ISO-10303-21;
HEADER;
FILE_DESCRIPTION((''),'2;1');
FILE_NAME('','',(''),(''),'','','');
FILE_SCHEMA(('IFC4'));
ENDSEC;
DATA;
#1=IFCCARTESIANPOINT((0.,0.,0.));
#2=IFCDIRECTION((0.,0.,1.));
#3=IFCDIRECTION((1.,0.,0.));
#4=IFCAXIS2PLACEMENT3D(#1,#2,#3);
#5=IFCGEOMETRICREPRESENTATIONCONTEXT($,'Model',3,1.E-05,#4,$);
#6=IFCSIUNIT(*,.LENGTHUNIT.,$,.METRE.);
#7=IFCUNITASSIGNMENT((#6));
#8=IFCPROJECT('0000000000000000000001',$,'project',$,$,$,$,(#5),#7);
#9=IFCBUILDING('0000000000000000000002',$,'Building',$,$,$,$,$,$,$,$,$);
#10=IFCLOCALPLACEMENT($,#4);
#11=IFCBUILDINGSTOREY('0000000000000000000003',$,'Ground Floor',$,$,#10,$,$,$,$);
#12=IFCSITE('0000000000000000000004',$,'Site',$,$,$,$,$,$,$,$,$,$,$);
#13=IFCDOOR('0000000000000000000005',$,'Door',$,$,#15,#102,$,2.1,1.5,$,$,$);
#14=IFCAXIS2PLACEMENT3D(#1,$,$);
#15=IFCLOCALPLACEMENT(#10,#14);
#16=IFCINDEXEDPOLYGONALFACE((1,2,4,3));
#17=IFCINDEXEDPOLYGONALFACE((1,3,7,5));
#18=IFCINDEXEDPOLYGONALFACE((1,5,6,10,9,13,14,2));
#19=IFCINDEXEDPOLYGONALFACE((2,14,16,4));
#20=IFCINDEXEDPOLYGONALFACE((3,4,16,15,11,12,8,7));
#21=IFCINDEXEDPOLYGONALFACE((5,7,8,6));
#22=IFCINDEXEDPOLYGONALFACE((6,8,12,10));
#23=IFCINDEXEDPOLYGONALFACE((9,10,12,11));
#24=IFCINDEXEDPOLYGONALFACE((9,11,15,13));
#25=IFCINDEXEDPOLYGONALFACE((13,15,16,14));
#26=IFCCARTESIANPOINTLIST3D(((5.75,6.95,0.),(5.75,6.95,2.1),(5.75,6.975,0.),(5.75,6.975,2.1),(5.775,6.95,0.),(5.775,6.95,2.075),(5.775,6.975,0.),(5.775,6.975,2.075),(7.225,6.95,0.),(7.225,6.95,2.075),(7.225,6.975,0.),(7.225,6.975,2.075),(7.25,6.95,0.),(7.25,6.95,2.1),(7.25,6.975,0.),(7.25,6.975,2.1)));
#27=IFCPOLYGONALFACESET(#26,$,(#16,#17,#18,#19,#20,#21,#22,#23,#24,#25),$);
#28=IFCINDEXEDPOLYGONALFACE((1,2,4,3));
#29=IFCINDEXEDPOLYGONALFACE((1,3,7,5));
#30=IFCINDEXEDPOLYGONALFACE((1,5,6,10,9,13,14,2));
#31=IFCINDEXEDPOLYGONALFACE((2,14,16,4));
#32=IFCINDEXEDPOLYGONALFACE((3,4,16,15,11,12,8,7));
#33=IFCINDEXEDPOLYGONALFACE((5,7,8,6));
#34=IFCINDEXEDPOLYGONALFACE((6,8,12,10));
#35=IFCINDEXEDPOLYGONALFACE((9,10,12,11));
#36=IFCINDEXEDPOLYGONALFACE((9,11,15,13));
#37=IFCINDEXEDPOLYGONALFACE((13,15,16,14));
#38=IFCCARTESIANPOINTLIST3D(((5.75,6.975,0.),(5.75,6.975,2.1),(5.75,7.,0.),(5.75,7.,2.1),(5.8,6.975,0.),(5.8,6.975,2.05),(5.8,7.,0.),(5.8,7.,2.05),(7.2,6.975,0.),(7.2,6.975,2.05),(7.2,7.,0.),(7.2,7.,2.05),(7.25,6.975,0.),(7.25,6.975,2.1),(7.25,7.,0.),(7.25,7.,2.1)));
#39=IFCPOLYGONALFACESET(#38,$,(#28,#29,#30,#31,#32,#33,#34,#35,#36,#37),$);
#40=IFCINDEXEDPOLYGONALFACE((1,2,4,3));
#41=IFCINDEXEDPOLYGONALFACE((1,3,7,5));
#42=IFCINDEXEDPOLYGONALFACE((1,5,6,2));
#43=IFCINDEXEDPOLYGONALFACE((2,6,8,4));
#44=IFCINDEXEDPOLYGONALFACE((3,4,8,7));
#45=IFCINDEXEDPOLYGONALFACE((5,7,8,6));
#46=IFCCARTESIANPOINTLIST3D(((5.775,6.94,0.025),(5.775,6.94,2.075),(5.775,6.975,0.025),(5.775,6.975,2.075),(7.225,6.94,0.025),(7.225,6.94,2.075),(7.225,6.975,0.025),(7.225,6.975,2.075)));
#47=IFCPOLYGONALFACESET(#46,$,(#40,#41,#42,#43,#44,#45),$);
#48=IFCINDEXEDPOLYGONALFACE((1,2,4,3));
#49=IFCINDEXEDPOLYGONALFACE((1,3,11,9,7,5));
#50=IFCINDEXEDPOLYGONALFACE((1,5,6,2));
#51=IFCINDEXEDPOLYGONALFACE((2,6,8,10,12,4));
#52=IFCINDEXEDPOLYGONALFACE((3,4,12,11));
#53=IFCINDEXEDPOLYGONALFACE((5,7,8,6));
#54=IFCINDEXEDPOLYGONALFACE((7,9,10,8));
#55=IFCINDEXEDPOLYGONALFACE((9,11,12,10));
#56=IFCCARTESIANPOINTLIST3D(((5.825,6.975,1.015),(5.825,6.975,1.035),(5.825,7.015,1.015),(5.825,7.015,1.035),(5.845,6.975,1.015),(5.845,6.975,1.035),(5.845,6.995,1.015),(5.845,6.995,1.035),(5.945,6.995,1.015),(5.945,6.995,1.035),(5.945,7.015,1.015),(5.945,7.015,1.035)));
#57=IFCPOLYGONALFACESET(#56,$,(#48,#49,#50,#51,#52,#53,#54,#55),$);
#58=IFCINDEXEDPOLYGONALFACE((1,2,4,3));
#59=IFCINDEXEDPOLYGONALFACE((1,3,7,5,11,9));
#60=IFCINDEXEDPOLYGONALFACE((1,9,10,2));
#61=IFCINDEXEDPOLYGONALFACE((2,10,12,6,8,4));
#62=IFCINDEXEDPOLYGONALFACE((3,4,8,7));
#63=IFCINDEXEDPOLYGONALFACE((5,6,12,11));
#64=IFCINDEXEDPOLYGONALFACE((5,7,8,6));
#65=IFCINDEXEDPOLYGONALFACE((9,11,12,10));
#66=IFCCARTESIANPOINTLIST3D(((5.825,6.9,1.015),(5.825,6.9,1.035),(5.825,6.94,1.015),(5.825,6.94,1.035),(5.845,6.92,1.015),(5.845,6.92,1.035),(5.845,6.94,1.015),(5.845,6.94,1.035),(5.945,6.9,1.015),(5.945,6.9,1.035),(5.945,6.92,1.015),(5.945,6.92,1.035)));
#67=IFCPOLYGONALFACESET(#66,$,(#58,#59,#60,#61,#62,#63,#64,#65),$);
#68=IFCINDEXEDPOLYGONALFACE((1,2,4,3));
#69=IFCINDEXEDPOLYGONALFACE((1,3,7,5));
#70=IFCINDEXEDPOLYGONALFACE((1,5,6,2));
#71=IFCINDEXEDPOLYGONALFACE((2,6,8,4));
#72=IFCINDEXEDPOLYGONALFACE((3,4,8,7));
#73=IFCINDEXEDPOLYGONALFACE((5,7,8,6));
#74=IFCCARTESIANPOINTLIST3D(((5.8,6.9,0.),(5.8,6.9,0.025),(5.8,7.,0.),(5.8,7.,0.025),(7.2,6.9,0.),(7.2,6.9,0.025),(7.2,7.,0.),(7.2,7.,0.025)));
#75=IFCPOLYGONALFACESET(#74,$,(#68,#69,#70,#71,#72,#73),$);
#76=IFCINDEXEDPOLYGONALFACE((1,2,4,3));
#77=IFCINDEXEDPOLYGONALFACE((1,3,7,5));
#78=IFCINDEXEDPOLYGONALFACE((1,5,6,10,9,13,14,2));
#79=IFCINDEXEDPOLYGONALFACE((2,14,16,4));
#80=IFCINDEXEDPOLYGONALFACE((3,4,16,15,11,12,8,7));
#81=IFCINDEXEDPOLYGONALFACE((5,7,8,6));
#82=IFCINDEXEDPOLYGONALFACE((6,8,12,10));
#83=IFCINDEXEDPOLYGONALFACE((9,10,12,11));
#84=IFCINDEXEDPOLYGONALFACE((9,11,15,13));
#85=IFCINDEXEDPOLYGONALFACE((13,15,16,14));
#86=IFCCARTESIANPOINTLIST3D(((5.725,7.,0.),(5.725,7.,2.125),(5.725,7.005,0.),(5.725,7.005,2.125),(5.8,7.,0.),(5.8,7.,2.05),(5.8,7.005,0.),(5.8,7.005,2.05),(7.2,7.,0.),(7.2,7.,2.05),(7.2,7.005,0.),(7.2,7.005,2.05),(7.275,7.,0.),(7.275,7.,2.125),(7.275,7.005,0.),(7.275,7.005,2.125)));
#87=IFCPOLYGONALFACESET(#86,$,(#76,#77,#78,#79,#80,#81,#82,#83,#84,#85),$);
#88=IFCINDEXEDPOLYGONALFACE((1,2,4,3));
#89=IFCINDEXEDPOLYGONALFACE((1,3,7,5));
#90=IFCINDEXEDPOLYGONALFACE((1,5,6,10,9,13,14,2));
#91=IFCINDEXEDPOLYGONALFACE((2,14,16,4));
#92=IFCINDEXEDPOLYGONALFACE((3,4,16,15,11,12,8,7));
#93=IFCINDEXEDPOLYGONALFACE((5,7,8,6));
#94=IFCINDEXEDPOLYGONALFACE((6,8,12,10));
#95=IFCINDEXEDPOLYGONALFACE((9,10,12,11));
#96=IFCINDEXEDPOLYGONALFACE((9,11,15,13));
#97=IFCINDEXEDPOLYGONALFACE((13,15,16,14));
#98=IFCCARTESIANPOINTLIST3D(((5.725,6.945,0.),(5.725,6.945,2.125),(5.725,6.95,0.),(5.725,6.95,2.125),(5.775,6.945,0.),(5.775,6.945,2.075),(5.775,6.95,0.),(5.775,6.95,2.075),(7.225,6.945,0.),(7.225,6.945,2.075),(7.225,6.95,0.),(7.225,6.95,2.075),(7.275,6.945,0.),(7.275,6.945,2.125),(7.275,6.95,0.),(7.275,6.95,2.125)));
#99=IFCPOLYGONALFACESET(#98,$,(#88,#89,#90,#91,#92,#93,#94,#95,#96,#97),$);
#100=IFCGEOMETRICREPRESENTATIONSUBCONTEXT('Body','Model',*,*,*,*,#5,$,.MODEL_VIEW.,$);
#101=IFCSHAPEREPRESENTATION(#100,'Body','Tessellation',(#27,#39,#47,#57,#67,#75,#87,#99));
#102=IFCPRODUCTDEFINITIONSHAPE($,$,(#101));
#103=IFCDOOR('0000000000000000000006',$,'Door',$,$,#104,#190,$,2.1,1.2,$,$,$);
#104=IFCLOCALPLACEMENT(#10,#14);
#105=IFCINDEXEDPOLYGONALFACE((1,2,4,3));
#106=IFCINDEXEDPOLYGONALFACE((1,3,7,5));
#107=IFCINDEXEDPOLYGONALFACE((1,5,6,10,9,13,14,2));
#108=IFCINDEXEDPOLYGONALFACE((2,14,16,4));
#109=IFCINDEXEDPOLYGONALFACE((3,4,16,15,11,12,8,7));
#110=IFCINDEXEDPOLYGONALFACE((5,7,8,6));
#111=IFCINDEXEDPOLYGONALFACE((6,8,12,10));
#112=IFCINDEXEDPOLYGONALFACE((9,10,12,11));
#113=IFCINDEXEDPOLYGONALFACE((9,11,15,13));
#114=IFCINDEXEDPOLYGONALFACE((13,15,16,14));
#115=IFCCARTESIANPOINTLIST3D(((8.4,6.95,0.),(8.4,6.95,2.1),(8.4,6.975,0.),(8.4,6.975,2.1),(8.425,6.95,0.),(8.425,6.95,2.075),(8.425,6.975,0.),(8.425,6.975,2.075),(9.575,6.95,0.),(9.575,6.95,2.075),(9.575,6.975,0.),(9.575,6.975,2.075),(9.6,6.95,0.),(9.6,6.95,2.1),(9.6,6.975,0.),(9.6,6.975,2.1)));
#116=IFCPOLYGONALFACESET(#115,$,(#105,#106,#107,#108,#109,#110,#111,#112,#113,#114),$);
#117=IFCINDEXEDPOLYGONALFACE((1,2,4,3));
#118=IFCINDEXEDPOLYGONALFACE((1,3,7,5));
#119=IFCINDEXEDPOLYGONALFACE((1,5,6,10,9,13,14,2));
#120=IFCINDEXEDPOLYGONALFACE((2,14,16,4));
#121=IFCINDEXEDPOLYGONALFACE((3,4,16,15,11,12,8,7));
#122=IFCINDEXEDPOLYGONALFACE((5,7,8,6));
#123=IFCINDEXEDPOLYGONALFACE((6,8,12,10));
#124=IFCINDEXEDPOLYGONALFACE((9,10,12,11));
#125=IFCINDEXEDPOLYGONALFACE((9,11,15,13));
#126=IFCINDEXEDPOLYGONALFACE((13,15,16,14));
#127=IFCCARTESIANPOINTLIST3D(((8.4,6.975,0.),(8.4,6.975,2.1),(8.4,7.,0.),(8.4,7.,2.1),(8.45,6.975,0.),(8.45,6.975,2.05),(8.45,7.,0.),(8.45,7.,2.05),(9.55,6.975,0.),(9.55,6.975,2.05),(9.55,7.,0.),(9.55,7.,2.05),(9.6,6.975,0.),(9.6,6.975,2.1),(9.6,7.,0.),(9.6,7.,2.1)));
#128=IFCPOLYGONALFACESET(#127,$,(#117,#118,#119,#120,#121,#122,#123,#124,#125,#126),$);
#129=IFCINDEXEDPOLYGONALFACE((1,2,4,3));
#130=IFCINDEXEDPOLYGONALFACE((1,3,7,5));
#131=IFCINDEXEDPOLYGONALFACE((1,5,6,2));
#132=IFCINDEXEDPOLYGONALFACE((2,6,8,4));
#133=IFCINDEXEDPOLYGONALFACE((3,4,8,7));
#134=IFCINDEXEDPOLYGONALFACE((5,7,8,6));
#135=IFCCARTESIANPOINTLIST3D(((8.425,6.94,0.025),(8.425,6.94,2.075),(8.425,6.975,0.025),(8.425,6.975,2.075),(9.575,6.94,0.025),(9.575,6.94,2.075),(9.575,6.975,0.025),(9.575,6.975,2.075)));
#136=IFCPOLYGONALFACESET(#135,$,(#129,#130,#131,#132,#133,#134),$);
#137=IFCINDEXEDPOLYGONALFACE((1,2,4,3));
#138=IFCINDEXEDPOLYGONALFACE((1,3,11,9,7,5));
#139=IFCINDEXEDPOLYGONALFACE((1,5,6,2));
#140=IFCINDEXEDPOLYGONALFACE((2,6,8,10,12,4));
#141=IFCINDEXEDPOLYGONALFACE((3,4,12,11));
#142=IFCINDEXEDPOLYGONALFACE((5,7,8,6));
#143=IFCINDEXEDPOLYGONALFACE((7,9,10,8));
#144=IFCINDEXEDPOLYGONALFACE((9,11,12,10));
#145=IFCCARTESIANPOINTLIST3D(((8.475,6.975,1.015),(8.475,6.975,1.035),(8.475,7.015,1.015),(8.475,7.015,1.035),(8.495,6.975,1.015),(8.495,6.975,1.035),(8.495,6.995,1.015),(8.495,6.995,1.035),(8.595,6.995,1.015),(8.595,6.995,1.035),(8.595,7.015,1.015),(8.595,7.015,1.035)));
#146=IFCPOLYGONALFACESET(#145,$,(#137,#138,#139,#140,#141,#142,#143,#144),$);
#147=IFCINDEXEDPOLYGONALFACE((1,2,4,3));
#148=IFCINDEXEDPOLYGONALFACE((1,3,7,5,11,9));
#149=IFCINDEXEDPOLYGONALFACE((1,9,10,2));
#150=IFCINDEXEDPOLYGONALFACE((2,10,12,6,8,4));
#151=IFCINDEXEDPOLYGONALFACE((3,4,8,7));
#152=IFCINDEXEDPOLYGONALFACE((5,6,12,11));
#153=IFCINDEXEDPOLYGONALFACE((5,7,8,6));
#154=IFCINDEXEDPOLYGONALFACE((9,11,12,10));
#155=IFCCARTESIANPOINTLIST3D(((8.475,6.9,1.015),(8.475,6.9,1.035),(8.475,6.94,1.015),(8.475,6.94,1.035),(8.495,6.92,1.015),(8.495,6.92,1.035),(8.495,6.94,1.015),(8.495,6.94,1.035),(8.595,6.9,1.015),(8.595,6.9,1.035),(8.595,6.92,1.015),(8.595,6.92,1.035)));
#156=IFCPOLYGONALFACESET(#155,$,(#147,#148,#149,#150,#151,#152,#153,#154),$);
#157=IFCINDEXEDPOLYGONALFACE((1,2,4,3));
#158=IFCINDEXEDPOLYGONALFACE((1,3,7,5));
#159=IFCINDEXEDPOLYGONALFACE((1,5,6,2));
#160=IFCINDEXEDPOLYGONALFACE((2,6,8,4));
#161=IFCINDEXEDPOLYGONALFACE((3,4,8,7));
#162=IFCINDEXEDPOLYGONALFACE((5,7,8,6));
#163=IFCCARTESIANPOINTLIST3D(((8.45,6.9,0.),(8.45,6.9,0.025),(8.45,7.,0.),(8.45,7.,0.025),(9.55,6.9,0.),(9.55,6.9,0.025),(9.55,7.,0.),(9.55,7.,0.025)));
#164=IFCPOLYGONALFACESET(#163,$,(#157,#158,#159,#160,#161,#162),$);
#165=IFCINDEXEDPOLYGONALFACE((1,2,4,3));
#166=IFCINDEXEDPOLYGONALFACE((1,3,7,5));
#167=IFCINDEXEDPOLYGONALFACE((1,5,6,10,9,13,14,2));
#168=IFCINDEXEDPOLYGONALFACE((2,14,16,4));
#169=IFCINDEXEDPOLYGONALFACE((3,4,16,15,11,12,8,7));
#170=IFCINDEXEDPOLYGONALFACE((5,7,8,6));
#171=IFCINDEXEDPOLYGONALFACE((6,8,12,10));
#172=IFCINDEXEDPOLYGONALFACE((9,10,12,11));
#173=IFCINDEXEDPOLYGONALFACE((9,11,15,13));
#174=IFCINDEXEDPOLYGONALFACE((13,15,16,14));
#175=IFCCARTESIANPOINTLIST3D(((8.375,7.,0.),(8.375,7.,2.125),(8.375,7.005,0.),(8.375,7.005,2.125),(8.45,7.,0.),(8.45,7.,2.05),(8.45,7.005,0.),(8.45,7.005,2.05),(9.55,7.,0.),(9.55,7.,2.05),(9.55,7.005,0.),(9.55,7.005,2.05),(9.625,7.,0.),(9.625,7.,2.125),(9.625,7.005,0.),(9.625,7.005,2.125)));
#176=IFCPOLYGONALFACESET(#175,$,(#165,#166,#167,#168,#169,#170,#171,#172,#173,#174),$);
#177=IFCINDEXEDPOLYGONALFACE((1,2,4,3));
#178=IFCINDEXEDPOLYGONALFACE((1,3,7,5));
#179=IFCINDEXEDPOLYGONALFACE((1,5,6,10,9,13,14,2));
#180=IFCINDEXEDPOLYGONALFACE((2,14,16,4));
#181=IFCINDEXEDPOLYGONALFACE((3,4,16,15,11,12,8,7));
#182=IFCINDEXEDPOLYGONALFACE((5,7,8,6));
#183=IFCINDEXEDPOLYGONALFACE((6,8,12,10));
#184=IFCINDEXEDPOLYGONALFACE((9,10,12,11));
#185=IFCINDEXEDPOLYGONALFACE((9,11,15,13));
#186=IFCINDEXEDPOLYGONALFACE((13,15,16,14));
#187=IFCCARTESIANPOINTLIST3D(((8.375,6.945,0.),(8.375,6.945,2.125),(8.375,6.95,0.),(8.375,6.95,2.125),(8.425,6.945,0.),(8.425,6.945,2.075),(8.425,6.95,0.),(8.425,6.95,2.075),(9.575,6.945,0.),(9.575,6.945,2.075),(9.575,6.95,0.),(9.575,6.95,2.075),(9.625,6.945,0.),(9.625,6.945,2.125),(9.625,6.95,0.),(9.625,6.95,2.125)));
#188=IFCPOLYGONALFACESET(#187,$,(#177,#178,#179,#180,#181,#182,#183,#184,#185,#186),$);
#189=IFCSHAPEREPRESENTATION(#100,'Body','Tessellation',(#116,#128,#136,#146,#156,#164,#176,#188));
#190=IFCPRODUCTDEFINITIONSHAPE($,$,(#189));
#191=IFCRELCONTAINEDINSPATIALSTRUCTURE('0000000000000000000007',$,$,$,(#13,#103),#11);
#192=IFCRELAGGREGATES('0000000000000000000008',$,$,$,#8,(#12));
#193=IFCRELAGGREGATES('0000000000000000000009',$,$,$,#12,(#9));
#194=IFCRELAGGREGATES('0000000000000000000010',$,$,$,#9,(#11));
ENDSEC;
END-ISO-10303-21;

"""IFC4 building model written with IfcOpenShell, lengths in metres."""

from ifc_helpers import new_model, si_unit, frame, origin_with_axes, place, context, subcontext, project, spatial, line, indexed_curve, outline, extrude, element, save


model = new_model("IFC4")

# Units and contexts
model_context = context("Model", 3, precision=1e-05, world=origin_with_axes())
body_context = subcontext(model_context, "Body", "Model", "MODEL_VIEW")
ifc_project = project(units=[si_unit("LENGTHUNIT", "METRE")], contexts=[model_context])

# Site, building, storey
site = spatial("IfcSite", under=ifc_project, Name="Site")
building = spatial("IfcBuilding", under=site, Name="Building")
storey_placement = place(None, origin_with_axes())
storey = spatial("IfcBuildingStorey", under=building, at=storey_placement, Name="Ground Floor")

# Doors
door_1_placement = place(storey_placement, frame((7.25, 7.0, 0.0), z_axis=(0.0, 0.0, 1.0), x_axis=(-1.0, 0.0, 0.0)))
element("IfcDoor", 1, at=door_1_placement, inside=storey, Name="Door", OverallHeight=2.1, OverallWidth=1.5, context=body_context, shape_type="SweptSolid", body=[
    extrude(outline(indexed_curve([(0.0, 0.0), (0.0, 2.1), (1.5, 2.1), (1.5, 0.0), (1.475, 0.0), (1.475, 2.075), (0.025, 2.075), (0.025, 0.0)], segments=[line(1, 2, 3, 4, 5, 6, 7, 8, 1)])), frame((0.0, 0.025, 0.0), z_axis=(0.0, -1.0, 0.0), x_axis=(1.0, 0.0, 0.0)), (0.0, 0.0, -1.0), 0.025),
    extrude(outline(indexed_curve([(0.0, 0.0), (0.0, 2.1), (1.5, 2.1), (1.5, 0.0), (1.45, 0.0), (1.45, 2.05), (0.05, 2.05), (0.05, 0.0)], segments=[line(1, 2, 3, 4, 5, 6, 7, 8, 1)])), frame((0.0, 0.0, 0.0), z_axis=(0.0, -1.0, 0.0), x_axis=(1.0, 0.0, 0.0)), (0.0, 0.0, -1.0), 0.025),
    extrude(outline(indexed_curve([(0.0, 0.0), (1.45, 0.0), (1.45, 0.035), (0.0, 0.035)], segments=[line(1, 2, 3, 4, 1)])), frame((0.025, 0.025, 0.025), z_axis=(0.0, 0.0, 1.0), x_axis=(1.0, 0.0, 0.0)), (0.0, 0.0, 1.0), 2.05),
    extrude(outline(indexed_curve([(0.0, 0.0), (0.0, -0.04), (-0.12, -0.04), (-0.12, -0.02), (-0.02, -0.02), (-0.02, 0.0)], segments=[line(1, 2, 3, 4, 5, 6, 1)])), frame((1.425, 0.025, 1.015), z_axis=(0.0, 0.0, 1.0), x_axis=(1.0, 0.0, 0.0)), (0.0, 0.0, 1.0), 0.02),
    extrude(outline(indexed_curve([(0.0, 0.0), (0.0, 0.04), (-0.12, 0.04), (-0.12, 0.02), (-0.02, 0.02), (-0.02, 0.0)], segments=[line(1, 2, 3, 4, 5, 6, 1)])), frame((1.425, 0.06, 1.015), z_axis=(0.0, 0.0, 1.0), x_axis=(1.0, 0.0, 0.0)), (0.0, 0.0, 1.0), 0.02),
    extrude(outline(indexed_curve([(0.0, 0.0), (1.4, 0.0), (1.4, 0.1), (0.0, 0.1)], segments=[line(1, 2, 3, 4, 1)])), frame((0.05, 0.0, 0.0), z_axis=(0.0, 0.0, 1.0), x_axis=(1.0, 0.0, 0.0)), (0.0, 0.0, 1.0), 0.025),
    extrude(outline(indexed_curve([(0.0, 0.0), (0.0, 2.125), (1.55, 2.125), (1.55, 0.0), (1.475, 0.0), (1.475, 2.05), (0.075, 2.05), (0.075, 0.0)], segments=[line(1, 2, 3, 4, 5, 6, 7, 8, 1)])), frame((-0.025, -0.005, 0.0), z_axis=(0.0, -1.0, 0.0), x_axis=(1.0, 0.0, 0.0)), (0.0, 0.0, -1.0), 0.005),
    extrude(outline(indexed_curve([(0.0, 0.0), (0.0, 2.125), (1.55, 2.125), (1.55, 0.0), (1.5, 0.0), (1.5, 2.075), (0.05, 2.075), (0.05, 0.0)], segments=[line(1, 2, 3, 4, 5, 6, 7, 8, 1)])), frame((-0.025, 0.05, 0.0), z_axis=(0.0, -1.0, 0.0), x_axis=(1.0, 0.0, 0.0)), (0.0, 0.0, -1.0), 0.005),
])
door_2_placement = place(storey_placement, frame((9.6, 7.0, 0.0), z_axis=(0.0, 0.0, 1.0), x_axis=(-1.0, 0.0, 0.0)))
element("IfcDoor", 2, at=door_2_placement, inside=storey, Name="Door", OverallHeight=2.1, OverallWidth=1.2, context=body_context, shape_type="SweptSolid", body=[
    extrude(outline(indexed_curve([(0.0, 0.0), (0.0, 2.1), (1.2, 2.1), (1.2, 0.0), (1.175, 0.0), (1.175, 2.075), (0.025, 2.075), (0.025, 0.0)], segments=[line(1, 2, 3, 4, 5, 6, 7, 8, 1)])), frame((0.0, 0.025, 0.0), z_axis=(0.0, -1.0, 0.0), x_axis=(1.0, 0.0, 0.0)), (0.0, 0.0, -1.0), 0.025),
    extrude(outline(indexed_curve([(0.0, 0.0), (0.0, 2.1), (1.2, 2.1), (1.2, 0.0), (1.15, 0.0), (1.15, 2.05), (0.05, 2.05), (0.05, 0.0)], segments=[line(1, 2, 3, 4, 5, 6, 7, 8, 1)])), frame((0.0, 0.0, 0.0), z_axis=(0.0, -1.0, 0.0), x_axis=(1.0, 0.0, 0.0)), (0.0, 0.0, -1.0), 0.025),
    extrude(outline(indexed_curve([(0.0, 0.0), (1.15, 0.0), (1.15, 0.035), (0.0, 0.035)], segments=[line(1, 2, 3, 4, 1)])), frame((0.025, 0.025, 0.025), z_axis=(0.0, 0.0, 1.0), x_axis=(1.0, 0.0, 0.0)), (0.0, 0.0, 1.0), 2.05),
    extrude(outline(indexed_curve([(0.0, 0.0), (0.0, -0.04), (-0.12, -0.04), (-0.12, -0.02), (-0.02, -0.02), (-0.02, 0.0)], segments=[line(1, 2, 3, 4, 5, 6, 1)])), frame((1.125, 0.025, 1.015), z_axis=(0.0, 0.0, 1.0), x_axis=(1.0, 0.0, 0.0)), (0.0, 0.0, 1.0), 0.02),
    extrude(outline(indexed_curve([(0.0, 0.0), (0.0, 0.04), (-0.12, 0.04), (-0.12, 0.02), (-0.02, 0.02), (-0.02, 0.0)], segments=[line(1, 2, 3, 4, 5, 6, 1)])), frame((1.125, 0.06, 1.015), z_axis=(0.0, 0.0, 1.0), x_axis=(1.0, 0.0, 0.0)), (0.0, 0.0, 1.0), 0.02),
    extrude(outline(indexed_curve([(0.0, 0.0), (1.1, 0.0), (1.1, 0.1), (0.0, 0.1)], segments=[line(1, 2, 3, 4, 1)])), frame((0.05, 0.0, 0.0), z_axis=(0.0, 0.0, 1.0), x_axis=(1.0, 0.0, 0.0)), (0.0, 0.0, 1.0), 0.025),
    extrude(outline(indexed_curve([(0.0, 0.0), (0.0, 2.125), (1.25, 2.125), (1.25, 0.0), (1.175, 0.0), (1.175, 2.05), (0.075, 2.05), (0.075, 0.0)], segments=[line(1, 2, 3, 4, 5, 6, 7, 8, 1)])), frame((-0.025, -0.005, 0.0), z_axis=(0.0, -1.0, 0.0), x_axis=(1.0, 0.0, 0.0)), (0.0, 0.0, -1.0), 0.005),
    extrude(outline(indexed_curve([(0.0, 0.0), (0.0, 2.125), (1.25, 2.125), (1.25, 0.0), (1.2, 0.0), (1.2, 2.075), (0.05, 2.075), (0.05, 0.0)], segments=[line(1, 2, 3, 4, 5, 6, 7, 8, 1)])), frame((-0.025, 0.05, 0.0), z_axis=(0.0, -1.0, 0.0), x_axis=(1.0, 0.0, 0.0)), (0.0, 0.0, -1.0), 0.005),
])

save(model, "model.ifc")
